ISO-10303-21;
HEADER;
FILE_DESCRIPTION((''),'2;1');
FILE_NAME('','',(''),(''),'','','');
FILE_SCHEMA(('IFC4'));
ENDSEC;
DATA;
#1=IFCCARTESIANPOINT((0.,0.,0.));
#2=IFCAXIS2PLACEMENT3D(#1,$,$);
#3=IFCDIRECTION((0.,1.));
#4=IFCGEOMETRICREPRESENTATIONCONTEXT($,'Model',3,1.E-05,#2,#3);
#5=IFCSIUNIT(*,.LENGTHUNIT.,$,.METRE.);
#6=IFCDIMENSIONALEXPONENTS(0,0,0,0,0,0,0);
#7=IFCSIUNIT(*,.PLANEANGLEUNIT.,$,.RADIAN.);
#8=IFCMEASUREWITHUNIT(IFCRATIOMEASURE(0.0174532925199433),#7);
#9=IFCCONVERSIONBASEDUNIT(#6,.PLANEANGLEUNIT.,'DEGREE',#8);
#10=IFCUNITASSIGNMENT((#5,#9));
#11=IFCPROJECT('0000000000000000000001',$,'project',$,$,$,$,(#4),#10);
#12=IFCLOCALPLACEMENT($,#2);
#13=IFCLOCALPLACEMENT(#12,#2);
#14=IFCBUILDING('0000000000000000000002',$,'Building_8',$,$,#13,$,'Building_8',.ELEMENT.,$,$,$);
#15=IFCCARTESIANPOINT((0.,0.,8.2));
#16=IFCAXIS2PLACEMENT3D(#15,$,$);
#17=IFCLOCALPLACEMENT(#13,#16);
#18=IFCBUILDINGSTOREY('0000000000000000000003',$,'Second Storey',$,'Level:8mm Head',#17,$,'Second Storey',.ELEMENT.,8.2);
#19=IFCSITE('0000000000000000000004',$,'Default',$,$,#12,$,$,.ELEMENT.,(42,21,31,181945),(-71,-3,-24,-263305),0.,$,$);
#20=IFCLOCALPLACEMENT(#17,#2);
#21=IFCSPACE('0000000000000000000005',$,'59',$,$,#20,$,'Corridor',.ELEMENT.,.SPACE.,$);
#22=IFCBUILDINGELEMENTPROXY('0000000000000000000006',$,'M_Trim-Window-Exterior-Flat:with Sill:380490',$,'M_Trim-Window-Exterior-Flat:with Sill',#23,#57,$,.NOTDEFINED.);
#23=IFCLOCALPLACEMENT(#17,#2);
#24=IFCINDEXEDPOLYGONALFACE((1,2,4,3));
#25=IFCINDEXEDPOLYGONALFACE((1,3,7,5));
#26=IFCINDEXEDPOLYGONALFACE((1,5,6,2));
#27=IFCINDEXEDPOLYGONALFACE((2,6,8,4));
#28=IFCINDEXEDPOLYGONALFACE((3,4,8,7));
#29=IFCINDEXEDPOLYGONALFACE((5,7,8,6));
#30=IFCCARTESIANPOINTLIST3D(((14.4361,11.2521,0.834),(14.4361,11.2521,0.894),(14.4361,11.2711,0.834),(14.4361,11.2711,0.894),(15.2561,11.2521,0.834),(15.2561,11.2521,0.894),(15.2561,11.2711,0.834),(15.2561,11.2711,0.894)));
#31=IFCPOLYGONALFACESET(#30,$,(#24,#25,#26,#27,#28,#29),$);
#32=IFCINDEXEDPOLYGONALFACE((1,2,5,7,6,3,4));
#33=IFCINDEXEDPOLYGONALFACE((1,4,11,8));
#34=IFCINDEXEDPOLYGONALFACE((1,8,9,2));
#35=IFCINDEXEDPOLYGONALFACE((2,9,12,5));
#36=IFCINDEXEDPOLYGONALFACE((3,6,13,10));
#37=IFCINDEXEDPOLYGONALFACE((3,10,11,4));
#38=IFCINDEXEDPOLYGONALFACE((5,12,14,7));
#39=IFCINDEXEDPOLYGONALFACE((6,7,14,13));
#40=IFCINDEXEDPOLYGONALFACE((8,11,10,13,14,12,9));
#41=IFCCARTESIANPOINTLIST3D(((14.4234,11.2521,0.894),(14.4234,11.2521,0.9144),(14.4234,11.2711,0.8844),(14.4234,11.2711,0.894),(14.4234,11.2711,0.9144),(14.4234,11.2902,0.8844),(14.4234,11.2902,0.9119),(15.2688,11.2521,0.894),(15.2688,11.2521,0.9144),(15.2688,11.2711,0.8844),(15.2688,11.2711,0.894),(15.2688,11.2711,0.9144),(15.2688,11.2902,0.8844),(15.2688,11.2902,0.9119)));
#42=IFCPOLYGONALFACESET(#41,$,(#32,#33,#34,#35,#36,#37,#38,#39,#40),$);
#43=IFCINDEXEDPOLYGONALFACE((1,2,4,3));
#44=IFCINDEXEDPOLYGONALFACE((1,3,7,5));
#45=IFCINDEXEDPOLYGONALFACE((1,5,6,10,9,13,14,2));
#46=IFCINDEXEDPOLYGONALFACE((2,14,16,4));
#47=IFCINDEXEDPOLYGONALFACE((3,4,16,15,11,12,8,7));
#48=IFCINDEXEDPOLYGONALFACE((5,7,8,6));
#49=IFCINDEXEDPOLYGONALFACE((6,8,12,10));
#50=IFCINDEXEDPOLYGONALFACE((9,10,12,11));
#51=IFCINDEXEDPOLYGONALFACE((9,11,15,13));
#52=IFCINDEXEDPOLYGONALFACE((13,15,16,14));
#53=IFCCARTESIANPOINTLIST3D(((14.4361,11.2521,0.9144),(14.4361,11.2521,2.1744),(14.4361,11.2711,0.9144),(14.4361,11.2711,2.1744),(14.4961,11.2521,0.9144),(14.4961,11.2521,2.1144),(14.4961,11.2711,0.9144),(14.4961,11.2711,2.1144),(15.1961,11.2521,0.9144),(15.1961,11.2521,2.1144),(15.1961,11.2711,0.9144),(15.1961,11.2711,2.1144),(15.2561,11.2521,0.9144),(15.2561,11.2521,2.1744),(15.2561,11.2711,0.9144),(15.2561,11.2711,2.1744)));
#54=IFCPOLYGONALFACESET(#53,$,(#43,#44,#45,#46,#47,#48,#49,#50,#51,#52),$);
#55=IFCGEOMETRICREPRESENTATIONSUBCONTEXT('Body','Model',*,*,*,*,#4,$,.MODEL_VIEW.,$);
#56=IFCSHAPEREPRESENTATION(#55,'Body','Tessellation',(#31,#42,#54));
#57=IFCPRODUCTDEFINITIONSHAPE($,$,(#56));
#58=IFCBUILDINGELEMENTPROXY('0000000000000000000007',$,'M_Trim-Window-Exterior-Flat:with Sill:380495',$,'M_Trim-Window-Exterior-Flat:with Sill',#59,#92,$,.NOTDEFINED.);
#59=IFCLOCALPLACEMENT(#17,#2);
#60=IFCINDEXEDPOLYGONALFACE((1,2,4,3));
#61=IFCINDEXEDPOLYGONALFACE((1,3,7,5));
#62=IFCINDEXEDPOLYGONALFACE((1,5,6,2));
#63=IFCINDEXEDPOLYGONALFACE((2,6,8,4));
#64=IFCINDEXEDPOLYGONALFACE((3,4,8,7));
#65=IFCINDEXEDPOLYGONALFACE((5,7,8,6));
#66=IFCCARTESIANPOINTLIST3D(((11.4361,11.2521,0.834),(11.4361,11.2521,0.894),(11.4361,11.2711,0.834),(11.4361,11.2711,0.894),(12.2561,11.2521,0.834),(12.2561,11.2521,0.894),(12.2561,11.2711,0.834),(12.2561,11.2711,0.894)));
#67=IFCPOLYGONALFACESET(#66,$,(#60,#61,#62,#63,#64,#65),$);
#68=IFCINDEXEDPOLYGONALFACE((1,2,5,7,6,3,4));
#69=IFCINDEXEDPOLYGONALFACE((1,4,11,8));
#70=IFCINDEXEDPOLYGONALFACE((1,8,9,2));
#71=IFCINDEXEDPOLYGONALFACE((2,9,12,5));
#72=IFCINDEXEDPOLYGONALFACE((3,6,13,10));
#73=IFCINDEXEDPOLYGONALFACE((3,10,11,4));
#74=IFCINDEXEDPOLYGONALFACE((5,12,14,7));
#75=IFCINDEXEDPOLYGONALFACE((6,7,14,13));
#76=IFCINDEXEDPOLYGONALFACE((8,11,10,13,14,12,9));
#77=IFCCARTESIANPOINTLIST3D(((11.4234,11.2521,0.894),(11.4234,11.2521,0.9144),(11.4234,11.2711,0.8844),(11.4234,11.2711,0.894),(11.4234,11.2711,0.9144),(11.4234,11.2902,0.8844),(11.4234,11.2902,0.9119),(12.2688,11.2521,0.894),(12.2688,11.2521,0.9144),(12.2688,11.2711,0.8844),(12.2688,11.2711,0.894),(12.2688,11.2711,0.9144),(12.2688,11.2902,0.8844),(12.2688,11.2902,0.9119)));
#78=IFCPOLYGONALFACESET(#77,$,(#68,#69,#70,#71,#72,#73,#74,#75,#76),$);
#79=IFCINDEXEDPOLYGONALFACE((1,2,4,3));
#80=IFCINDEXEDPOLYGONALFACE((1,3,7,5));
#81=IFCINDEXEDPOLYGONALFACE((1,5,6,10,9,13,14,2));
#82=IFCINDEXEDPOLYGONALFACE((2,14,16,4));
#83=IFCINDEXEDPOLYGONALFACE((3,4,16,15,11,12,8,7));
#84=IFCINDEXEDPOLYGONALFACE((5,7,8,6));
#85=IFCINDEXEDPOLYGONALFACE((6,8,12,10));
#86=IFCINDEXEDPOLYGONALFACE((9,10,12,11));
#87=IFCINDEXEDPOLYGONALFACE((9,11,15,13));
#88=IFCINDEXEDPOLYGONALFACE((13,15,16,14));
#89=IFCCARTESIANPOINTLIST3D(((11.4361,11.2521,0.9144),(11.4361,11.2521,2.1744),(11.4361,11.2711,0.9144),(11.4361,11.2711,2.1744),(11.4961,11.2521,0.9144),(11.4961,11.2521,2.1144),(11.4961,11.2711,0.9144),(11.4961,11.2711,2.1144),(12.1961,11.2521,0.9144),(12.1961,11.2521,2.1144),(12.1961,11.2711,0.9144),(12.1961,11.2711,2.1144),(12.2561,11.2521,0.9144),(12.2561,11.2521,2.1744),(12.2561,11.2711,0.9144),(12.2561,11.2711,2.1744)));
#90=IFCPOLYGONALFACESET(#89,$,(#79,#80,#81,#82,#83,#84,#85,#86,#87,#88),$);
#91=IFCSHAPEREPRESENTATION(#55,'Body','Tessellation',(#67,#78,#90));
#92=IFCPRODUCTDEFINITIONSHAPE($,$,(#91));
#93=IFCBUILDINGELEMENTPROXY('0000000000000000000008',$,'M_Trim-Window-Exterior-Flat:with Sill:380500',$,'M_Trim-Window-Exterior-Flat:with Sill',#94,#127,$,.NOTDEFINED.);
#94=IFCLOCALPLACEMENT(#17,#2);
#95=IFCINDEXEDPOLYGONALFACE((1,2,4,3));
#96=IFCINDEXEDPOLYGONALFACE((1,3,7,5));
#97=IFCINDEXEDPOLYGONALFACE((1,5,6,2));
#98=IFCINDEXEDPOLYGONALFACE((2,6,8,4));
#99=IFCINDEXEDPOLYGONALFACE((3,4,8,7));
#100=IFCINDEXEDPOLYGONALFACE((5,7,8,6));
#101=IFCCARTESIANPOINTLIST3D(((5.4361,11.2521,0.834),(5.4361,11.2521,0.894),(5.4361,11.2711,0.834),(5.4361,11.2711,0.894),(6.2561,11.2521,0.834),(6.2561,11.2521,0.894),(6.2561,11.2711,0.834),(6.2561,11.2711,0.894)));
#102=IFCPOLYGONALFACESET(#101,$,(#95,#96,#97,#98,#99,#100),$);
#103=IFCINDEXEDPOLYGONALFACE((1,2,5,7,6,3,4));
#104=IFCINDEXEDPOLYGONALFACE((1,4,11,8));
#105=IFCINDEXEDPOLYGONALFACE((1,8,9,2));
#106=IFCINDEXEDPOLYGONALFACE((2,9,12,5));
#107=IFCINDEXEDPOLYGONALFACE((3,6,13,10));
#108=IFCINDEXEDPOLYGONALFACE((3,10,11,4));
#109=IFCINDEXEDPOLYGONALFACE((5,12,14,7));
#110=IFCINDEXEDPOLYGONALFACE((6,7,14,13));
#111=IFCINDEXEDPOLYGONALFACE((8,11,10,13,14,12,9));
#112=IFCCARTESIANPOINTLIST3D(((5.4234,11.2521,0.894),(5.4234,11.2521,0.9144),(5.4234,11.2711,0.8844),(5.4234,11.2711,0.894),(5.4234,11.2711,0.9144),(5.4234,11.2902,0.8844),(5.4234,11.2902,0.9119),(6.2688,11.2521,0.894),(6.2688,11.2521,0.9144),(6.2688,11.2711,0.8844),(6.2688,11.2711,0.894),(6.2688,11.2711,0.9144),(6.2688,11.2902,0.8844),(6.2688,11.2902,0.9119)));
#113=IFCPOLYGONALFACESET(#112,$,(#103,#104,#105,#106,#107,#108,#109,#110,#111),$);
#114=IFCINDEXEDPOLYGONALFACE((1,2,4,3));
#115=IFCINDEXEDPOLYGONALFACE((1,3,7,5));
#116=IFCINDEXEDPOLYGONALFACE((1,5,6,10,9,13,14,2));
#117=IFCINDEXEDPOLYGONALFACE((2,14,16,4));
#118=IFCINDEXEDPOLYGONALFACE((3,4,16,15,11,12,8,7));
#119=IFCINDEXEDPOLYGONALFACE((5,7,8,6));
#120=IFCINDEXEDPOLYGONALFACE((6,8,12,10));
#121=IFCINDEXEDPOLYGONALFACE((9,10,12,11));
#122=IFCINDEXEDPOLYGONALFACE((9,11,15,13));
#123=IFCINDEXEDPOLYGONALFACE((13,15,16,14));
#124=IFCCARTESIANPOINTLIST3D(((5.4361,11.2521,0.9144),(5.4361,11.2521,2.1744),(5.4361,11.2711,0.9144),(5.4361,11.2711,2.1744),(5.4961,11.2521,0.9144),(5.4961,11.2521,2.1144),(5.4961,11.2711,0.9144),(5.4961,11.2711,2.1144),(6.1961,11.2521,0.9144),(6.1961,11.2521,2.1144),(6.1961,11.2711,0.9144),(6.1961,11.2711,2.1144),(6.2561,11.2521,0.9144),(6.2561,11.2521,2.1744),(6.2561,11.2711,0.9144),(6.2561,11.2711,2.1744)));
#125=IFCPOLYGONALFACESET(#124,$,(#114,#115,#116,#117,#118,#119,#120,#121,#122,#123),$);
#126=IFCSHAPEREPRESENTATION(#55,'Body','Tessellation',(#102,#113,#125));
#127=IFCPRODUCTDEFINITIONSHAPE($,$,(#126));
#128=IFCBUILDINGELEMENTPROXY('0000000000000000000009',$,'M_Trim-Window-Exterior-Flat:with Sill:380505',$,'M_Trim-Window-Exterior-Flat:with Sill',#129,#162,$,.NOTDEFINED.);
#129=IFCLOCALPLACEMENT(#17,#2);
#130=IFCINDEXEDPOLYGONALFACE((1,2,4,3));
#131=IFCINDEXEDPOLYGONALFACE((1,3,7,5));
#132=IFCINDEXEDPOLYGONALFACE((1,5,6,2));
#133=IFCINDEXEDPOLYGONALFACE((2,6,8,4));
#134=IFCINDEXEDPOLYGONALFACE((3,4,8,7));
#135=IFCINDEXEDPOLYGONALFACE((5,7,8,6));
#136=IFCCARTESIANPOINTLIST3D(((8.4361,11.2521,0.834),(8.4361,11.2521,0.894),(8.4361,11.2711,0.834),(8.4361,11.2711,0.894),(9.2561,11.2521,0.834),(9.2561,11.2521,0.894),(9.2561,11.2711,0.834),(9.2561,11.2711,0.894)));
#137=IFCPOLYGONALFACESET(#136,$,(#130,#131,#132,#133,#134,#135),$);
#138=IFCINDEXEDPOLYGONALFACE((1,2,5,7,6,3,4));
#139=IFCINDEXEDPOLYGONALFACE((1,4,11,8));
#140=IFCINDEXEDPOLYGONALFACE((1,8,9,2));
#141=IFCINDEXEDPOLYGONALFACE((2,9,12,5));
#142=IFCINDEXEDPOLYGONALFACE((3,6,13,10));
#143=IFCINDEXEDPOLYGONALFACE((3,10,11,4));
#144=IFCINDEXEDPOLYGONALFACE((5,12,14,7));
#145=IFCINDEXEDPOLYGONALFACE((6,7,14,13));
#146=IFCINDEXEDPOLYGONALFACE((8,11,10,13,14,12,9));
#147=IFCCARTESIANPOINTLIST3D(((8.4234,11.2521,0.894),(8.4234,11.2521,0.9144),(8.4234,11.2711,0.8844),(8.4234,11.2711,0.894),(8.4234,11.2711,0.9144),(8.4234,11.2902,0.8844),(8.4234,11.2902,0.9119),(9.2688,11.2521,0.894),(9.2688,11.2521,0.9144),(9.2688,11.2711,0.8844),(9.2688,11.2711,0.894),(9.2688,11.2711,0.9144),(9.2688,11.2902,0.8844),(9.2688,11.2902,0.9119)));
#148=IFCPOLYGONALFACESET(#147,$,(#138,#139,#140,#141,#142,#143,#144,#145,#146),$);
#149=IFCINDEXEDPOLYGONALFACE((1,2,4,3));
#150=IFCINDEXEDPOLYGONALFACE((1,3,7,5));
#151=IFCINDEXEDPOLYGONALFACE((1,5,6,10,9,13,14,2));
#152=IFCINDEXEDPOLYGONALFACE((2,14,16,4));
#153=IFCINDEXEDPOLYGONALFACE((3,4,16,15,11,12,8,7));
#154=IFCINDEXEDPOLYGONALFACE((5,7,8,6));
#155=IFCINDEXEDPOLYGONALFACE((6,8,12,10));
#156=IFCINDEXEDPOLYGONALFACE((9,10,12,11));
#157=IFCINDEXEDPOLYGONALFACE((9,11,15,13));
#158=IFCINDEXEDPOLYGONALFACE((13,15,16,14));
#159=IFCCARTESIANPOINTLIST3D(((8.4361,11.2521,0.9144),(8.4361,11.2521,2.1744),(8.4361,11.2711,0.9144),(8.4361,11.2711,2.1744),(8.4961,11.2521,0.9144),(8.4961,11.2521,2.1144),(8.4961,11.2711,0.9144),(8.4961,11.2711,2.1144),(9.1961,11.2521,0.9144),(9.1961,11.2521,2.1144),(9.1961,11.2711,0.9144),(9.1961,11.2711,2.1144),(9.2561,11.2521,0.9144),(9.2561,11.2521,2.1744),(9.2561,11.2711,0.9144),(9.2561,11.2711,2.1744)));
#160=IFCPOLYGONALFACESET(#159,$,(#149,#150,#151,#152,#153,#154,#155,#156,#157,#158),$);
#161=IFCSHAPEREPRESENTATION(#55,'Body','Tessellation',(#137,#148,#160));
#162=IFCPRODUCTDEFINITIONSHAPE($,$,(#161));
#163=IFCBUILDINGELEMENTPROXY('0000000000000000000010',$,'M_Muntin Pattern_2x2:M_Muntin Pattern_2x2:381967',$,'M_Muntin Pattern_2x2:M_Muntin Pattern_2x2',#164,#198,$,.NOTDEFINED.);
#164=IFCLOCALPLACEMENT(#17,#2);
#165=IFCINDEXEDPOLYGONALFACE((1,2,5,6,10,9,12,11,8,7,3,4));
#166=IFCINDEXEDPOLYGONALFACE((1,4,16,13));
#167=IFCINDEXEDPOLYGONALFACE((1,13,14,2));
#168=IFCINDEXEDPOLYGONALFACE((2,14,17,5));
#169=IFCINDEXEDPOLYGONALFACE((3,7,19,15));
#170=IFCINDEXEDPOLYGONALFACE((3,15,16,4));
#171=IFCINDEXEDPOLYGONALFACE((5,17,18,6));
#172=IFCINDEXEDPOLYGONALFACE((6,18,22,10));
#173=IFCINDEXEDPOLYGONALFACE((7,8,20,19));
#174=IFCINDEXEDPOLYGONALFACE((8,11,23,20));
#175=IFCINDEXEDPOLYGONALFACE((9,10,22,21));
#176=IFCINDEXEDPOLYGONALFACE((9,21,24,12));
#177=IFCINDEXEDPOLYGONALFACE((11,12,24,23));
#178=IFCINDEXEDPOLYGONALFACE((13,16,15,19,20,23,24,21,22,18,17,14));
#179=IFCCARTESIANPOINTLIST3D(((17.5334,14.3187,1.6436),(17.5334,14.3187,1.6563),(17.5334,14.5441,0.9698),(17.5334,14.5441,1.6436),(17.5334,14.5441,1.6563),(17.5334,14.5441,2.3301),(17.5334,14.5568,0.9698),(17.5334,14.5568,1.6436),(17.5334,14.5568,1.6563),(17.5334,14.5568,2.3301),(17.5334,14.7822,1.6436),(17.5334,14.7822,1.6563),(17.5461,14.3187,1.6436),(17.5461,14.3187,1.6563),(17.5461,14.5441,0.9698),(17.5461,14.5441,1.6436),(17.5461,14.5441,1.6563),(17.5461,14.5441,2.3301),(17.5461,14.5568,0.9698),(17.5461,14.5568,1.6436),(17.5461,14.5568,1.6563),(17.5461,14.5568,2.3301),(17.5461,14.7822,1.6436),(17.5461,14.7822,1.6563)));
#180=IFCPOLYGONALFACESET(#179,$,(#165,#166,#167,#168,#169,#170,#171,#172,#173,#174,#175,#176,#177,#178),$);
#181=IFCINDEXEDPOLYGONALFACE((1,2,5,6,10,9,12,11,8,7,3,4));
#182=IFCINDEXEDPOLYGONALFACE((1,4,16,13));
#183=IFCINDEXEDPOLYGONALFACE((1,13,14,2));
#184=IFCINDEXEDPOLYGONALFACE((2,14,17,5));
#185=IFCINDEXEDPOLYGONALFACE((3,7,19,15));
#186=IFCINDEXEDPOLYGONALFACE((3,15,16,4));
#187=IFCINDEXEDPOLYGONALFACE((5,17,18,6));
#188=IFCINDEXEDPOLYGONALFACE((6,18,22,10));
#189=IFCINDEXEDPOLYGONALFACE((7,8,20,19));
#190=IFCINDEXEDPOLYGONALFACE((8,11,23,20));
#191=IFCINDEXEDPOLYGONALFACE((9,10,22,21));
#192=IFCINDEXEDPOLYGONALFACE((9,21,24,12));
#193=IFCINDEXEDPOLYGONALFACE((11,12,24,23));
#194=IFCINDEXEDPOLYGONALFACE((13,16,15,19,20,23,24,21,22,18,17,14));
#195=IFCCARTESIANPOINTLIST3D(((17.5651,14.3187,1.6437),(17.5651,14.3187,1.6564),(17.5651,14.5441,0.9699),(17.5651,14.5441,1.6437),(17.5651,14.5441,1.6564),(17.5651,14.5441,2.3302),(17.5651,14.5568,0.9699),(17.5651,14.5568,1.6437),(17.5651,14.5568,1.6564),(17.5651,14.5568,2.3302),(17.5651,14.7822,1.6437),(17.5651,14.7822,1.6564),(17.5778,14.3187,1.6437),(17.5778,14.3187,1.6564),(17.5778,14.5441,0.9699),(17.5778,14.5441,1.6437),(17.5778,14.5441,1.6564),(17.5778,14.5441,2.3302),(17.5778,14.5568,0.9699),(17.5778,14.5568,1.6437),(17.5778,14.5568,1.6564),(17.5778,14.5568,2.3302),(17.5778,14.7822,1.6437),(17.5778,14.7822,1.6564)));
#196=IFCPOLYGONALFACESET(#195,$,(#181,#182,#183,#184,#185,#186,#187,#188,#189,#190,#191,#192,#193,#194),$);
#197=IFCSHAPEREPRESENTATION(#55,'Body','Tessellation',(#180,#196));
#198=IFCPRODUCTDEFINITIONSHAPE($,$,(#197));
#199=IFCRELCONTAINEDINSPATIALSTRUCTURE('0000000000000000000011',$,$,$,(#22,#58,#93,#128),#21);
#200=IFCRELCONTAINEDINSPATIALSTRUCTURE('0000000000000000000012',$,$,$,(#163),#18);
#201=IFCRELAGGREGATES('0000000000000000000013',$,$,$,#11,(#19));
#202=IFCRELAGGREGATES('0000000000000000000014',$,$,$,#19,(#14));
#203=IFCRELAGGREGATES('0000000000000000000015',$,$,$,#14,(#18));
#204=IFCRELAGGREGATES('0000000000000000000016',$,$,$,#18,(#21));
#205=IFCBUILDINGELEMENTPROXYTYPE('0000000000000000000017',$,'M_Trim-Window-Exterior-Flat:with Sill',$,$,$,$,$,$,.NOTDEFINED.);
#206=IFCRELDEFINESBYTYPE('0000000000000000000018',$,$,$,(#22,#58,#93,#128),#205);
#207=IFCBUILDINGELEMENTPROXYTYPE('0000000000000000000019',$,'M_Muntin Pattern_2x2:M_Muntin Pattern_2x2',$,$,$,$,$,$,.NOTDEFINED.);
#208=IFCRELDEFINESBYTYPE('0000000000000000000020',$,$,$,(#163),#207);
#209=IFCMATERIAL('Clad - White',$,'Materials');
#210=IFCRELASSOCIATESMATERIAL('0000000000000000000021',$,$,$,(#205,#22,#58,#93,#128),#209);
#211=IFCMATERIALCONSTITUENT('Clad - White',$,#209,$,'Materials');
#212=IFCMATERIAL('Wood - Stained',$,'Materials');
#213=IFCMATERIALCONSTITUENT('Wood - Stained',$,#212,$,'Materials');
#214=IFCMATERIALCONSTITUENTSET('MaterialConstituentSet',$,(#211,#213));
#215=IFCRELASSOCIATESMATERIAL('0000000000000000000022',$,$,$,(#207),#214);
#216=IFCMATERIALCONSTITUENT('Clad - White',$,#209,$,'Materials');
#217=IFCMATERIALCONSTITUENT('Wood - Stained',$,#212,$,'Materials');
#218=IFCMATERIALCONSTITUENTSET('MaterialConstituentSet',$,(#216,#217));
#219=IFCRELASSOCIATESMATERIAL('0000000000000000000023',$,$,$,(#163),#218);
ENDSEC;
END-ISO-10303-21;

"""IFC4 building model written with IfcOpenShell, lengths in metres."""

from ifc_helpers import new_model, entity, si_unit, converted_unit, direction, frame, origin, place, context, subcontext, project, spatial, indexed_curve, outline, extrude, source, transform, mapped, material, constituent, constituent_set, type_object, type_shapes, element, save


model = new_model("IFC4")

# Units and contexts
model_context = context("Model", 3, precision=1e-05, world=origin(), true_north=direction((0.0, 1.0)))
body_context = subcontext(model_context, "Body", "Model", "MODEL_VIEW")
ifc_project = project(units=[si_unit("LENGTHUNIT", "METRE"), converted_unit("PLANEANGLEUNIT", "DEGREE", entity("IfcRatioMeasure", 0.0174532925199433), si_unit("PLANEANGLEUNIT", "RADIAN"), dimensions=[0, 0, 0, 0, 0, 0, 0])], contexts=[model_context])

# Site, building, storey
site_placement = place(None, origin())
site = spatial("IfcSite", under=ifc_project, at=site_placement, Name="Default", CompositionType="ELEMENT", RefLatitude=(42, 21, 31, 181945), RefLongitude=(-71, -3, -24, -263305), RefElevation=0.0)
building_placement = place(site_placement, origin())
building = spatial("IfcBuilding", under=site, at=building_placement, Name="Building_8", LongName="Building_8", CompositionType="ELEMENT")
storey_placement = place(building_placement, frame((0.0, 0.0, 8.2)))
storey = spatial("IfcBuildingStorey", under=building, at=storey_placement, Name="Second Storey", ObjectType="Level:8mm Head", LongName="Second Storey", CompositionType="ELEMENT", Elevation=8.2)

# Shared definitions
ifc_material_1 = material(Name="Clad - White", Category="Materials")
ifc_material_2 = material(Name="Wood - Stained", Category="Materials")

# Shared definitions
space_1_placement = place(storey_placement, origin())
space_1 = spatial("IfcSpace", under=storey, at=space_1_placement, Name="59", LongName="Corridor", CompositionType="ELEMENT", PredefinedType="SPACE")

# Building element proxies
building_element_proxy_type_1 = type_object("IfcBuildingElementProxyType", Name="M_Trim-Window-Exterior-Flat:with Sill", PredefinedType="NOTDEFINED", material=ifc_material_1)
shared_shape_1 = source(origin(), body_context, "Body", "SweptSolid", [
    extrude(outline(indexed_curve([(-0.41, -0.03), (0.41, -0.03), (0.41, 0.03), (-0.41, 0.03), (-0.41, -0.03)], self_intersect=False)), frame((0.0, -1.2504, 0.0), z_axis=(0.0, 0.0, 1.0), x_axis=(-1.0, 0.0, 0.0)), (0.0, 0.0, 1.0), 0.0191),
    extrude(outline(indexed_curve([(-0.019, -0.0152), (0.0, -0.0152), (0.0, -0.0057), (0.019, -0.0057), (0.019, 0.0148), (0.0, 0.0148), (-0.019, 0.0123), (-0.019, -0.0152)], self_intersect=False)), frame((-0.4227, -1.2148, 0.019), z_axis=(1.0, 0.0, 0.0), x_axis=(0.0, 0.0, -1.0)), (0.0, 0.0, 1.0), 0.8454),
    extrude(outline(indexed_curve([(-0.645, -0.41), (0.615, -0.41), (0.615, -0.35), (-0.585, -0.35), (-0.585, 0.35), (0.615, 0.35), (0.615, 0.41), (-0.645, 0.41), (-0.645, -0.41)], self_intersect=False)), frame((0.0, -0.585, 0.0), z_axis=(0.0, 0.0, 1.0), x_axis=(0.0, -1.0, 0.0)), (0.0, 0.0, 1.0), 0.0191),
])
type_shapes(building_element_proxy_type_1, [shared_shape_1])
for number, where, z_axis, x_axis, name in (
    (1, (14.8461, 11.2521, 2.1144), (0.0, 1.0, 0.0), (-1.0, 0.0, 0.0), "M_Trim-Window-Exterior-Flat:with Sill:380490"),
    (2, (11.8461, 11.2521, 2.1144), (0.0, 1.0, 0.0), (-1.0, 0.0, 0.0), "M_Trim-Window-Exterior-Flat:with Sill:380495"),
    (3, (5.8461, 11.2521, 2.1144), (0.0, 1.0, 0.0), (-1.0, 0.0, 0.0), "M_Trim-Window-Exterior-Flat:with Sill:380500"),
    (4, (8.8461, 11.2521, 2.1144), (0.0, 1.0, 0.0), (-1.0, 0.0, 0.0), "M_Trim-Window-Exterior-Flat:with Sill:380505"),
):
    element("IfcBuildingElementProxy", number, at=place(space_1_placement, frame(where, z_axis=z_axis, x_axis=x_axis)), inside=space_1, type_object=building_element_proxy_type_1, material=ifc_material_1, Name=name, ObjectType="M_Trim-Window-Exterior-Flat:with Sill", PredefinedType="NOTDEFINED", context=body_context, shape_type="MappedRepresentation", body=[
        mapped(shared_shape_1, transform((0.0, 0.0, 0.0), scale=1.0)),
    ])
ifc_constituent_1 = constituent(ifc_material_1, Name="Clad - White", Category="Materials")
ifc_constituent_2 = constituent(ifc_material_2, Name="Wood - Stained", Category="Materials")
ifc_constituent_set_1 = constituent_set(constituents=[ifc_constituent_1, ifc_constituent_2], Name="MaterialConstituentSet")
ifc_constituent_3 = constituent(ifc_material_1, Name="Clad - White", Category="Materials")
ifc_constituent_4 = constituent(ifc_material_2, Name="Wood - Stained", Category="Materials")
ifc_constituent_set_2 = constituent_set(constituents=[ifc_constituent_3, ifc_constituent_4], Name="MaterialConstituentSet")
building_element_proxy_type_2 = type_object("IfcBuildingElementProxyType", Name="M_Muntin Pattern_2x2:M_Muntin Pattern_2x2", PredefinedType="NOTDEFINED", material=ifc_constituent_set_2)
shared_shape_2 = source(origin(), body_context, "Body", "SweptSolid", [
    extrude(outline(indexed_curve([(0.0064, -0.0064), (0.6801, -0.0064), (0.6801, 0.0063), (0.0064, 0.0063), (0.0064, 0.2317), (-0.0063, 0.2317), (-0.0063, 0.0063), (-0.6802, 0.0063), (-0.6802, -0.0064), (-0.0063, -0.0064), (-0.0063, -0.2317), (0.0064, -0.2317), (0.0064, -0.0064)], self_intersect=False)), frame((0.0, -0.0222, 0.6801), z_axis=(0.0, 1.0, 0.0), x_axis=(0.0, 0.0, 1.0)), (0.0, 0.0, 1.0), 0.0127),
    extrude(outline(indexed_curve([(0.0064, -0.0064), (0.6802, -0.0064), (0.6802, 0.0063), (0.0064, 0.0063), (0.0064, 0.2317), (-0.0063, 0.2317), (-0.0063, 0.0063), (-0.6802, 0.0063), (-0.6802, -0.0064), (-0.0063, -0.0064), (-0.0063, -0.2317), (0.0064, -0.2317), (0.0064, -0.0064)], self_intersect=False)), frame((0.0, 0.0095, 0.6802), z_axis=(0.0, 1.0, 0.0), x_axis=(0.0, 0.0, 1.0)), (0.0, 0.0, 1.0), 0.0127),
])
type_shapes(building_element_proxy_type_2, [shared_shape_2])
proxy_1_placement = place(storey_placement, frame((17.5556, 14.5505, 0.9699), z_axis=(0.0, 0.0, 1.0), x_axis=(0.0, -1.0, 0.0)))
element("IfcBuildingElementProxy", 5, at=proxy_1_placement, inside=storey, type_object=building_element_proxy_type_2, material=ifc_constituent_set_1, Name="M_Muntin Pattern_2x2:M_Muntin Pattern_2x2:381967", ObjectType="M_Muntin Pattern_2x2:M_Muntin Pattern_2x2", PredefinedType="NOTDEFINED", context=body_context, shape_type="MappedRepresentation", body=[
    mapped(shared_shape_2, transform((0.0, 0.0, 0.0), scale=1.0)),
])

save(model, "model.ifc")
